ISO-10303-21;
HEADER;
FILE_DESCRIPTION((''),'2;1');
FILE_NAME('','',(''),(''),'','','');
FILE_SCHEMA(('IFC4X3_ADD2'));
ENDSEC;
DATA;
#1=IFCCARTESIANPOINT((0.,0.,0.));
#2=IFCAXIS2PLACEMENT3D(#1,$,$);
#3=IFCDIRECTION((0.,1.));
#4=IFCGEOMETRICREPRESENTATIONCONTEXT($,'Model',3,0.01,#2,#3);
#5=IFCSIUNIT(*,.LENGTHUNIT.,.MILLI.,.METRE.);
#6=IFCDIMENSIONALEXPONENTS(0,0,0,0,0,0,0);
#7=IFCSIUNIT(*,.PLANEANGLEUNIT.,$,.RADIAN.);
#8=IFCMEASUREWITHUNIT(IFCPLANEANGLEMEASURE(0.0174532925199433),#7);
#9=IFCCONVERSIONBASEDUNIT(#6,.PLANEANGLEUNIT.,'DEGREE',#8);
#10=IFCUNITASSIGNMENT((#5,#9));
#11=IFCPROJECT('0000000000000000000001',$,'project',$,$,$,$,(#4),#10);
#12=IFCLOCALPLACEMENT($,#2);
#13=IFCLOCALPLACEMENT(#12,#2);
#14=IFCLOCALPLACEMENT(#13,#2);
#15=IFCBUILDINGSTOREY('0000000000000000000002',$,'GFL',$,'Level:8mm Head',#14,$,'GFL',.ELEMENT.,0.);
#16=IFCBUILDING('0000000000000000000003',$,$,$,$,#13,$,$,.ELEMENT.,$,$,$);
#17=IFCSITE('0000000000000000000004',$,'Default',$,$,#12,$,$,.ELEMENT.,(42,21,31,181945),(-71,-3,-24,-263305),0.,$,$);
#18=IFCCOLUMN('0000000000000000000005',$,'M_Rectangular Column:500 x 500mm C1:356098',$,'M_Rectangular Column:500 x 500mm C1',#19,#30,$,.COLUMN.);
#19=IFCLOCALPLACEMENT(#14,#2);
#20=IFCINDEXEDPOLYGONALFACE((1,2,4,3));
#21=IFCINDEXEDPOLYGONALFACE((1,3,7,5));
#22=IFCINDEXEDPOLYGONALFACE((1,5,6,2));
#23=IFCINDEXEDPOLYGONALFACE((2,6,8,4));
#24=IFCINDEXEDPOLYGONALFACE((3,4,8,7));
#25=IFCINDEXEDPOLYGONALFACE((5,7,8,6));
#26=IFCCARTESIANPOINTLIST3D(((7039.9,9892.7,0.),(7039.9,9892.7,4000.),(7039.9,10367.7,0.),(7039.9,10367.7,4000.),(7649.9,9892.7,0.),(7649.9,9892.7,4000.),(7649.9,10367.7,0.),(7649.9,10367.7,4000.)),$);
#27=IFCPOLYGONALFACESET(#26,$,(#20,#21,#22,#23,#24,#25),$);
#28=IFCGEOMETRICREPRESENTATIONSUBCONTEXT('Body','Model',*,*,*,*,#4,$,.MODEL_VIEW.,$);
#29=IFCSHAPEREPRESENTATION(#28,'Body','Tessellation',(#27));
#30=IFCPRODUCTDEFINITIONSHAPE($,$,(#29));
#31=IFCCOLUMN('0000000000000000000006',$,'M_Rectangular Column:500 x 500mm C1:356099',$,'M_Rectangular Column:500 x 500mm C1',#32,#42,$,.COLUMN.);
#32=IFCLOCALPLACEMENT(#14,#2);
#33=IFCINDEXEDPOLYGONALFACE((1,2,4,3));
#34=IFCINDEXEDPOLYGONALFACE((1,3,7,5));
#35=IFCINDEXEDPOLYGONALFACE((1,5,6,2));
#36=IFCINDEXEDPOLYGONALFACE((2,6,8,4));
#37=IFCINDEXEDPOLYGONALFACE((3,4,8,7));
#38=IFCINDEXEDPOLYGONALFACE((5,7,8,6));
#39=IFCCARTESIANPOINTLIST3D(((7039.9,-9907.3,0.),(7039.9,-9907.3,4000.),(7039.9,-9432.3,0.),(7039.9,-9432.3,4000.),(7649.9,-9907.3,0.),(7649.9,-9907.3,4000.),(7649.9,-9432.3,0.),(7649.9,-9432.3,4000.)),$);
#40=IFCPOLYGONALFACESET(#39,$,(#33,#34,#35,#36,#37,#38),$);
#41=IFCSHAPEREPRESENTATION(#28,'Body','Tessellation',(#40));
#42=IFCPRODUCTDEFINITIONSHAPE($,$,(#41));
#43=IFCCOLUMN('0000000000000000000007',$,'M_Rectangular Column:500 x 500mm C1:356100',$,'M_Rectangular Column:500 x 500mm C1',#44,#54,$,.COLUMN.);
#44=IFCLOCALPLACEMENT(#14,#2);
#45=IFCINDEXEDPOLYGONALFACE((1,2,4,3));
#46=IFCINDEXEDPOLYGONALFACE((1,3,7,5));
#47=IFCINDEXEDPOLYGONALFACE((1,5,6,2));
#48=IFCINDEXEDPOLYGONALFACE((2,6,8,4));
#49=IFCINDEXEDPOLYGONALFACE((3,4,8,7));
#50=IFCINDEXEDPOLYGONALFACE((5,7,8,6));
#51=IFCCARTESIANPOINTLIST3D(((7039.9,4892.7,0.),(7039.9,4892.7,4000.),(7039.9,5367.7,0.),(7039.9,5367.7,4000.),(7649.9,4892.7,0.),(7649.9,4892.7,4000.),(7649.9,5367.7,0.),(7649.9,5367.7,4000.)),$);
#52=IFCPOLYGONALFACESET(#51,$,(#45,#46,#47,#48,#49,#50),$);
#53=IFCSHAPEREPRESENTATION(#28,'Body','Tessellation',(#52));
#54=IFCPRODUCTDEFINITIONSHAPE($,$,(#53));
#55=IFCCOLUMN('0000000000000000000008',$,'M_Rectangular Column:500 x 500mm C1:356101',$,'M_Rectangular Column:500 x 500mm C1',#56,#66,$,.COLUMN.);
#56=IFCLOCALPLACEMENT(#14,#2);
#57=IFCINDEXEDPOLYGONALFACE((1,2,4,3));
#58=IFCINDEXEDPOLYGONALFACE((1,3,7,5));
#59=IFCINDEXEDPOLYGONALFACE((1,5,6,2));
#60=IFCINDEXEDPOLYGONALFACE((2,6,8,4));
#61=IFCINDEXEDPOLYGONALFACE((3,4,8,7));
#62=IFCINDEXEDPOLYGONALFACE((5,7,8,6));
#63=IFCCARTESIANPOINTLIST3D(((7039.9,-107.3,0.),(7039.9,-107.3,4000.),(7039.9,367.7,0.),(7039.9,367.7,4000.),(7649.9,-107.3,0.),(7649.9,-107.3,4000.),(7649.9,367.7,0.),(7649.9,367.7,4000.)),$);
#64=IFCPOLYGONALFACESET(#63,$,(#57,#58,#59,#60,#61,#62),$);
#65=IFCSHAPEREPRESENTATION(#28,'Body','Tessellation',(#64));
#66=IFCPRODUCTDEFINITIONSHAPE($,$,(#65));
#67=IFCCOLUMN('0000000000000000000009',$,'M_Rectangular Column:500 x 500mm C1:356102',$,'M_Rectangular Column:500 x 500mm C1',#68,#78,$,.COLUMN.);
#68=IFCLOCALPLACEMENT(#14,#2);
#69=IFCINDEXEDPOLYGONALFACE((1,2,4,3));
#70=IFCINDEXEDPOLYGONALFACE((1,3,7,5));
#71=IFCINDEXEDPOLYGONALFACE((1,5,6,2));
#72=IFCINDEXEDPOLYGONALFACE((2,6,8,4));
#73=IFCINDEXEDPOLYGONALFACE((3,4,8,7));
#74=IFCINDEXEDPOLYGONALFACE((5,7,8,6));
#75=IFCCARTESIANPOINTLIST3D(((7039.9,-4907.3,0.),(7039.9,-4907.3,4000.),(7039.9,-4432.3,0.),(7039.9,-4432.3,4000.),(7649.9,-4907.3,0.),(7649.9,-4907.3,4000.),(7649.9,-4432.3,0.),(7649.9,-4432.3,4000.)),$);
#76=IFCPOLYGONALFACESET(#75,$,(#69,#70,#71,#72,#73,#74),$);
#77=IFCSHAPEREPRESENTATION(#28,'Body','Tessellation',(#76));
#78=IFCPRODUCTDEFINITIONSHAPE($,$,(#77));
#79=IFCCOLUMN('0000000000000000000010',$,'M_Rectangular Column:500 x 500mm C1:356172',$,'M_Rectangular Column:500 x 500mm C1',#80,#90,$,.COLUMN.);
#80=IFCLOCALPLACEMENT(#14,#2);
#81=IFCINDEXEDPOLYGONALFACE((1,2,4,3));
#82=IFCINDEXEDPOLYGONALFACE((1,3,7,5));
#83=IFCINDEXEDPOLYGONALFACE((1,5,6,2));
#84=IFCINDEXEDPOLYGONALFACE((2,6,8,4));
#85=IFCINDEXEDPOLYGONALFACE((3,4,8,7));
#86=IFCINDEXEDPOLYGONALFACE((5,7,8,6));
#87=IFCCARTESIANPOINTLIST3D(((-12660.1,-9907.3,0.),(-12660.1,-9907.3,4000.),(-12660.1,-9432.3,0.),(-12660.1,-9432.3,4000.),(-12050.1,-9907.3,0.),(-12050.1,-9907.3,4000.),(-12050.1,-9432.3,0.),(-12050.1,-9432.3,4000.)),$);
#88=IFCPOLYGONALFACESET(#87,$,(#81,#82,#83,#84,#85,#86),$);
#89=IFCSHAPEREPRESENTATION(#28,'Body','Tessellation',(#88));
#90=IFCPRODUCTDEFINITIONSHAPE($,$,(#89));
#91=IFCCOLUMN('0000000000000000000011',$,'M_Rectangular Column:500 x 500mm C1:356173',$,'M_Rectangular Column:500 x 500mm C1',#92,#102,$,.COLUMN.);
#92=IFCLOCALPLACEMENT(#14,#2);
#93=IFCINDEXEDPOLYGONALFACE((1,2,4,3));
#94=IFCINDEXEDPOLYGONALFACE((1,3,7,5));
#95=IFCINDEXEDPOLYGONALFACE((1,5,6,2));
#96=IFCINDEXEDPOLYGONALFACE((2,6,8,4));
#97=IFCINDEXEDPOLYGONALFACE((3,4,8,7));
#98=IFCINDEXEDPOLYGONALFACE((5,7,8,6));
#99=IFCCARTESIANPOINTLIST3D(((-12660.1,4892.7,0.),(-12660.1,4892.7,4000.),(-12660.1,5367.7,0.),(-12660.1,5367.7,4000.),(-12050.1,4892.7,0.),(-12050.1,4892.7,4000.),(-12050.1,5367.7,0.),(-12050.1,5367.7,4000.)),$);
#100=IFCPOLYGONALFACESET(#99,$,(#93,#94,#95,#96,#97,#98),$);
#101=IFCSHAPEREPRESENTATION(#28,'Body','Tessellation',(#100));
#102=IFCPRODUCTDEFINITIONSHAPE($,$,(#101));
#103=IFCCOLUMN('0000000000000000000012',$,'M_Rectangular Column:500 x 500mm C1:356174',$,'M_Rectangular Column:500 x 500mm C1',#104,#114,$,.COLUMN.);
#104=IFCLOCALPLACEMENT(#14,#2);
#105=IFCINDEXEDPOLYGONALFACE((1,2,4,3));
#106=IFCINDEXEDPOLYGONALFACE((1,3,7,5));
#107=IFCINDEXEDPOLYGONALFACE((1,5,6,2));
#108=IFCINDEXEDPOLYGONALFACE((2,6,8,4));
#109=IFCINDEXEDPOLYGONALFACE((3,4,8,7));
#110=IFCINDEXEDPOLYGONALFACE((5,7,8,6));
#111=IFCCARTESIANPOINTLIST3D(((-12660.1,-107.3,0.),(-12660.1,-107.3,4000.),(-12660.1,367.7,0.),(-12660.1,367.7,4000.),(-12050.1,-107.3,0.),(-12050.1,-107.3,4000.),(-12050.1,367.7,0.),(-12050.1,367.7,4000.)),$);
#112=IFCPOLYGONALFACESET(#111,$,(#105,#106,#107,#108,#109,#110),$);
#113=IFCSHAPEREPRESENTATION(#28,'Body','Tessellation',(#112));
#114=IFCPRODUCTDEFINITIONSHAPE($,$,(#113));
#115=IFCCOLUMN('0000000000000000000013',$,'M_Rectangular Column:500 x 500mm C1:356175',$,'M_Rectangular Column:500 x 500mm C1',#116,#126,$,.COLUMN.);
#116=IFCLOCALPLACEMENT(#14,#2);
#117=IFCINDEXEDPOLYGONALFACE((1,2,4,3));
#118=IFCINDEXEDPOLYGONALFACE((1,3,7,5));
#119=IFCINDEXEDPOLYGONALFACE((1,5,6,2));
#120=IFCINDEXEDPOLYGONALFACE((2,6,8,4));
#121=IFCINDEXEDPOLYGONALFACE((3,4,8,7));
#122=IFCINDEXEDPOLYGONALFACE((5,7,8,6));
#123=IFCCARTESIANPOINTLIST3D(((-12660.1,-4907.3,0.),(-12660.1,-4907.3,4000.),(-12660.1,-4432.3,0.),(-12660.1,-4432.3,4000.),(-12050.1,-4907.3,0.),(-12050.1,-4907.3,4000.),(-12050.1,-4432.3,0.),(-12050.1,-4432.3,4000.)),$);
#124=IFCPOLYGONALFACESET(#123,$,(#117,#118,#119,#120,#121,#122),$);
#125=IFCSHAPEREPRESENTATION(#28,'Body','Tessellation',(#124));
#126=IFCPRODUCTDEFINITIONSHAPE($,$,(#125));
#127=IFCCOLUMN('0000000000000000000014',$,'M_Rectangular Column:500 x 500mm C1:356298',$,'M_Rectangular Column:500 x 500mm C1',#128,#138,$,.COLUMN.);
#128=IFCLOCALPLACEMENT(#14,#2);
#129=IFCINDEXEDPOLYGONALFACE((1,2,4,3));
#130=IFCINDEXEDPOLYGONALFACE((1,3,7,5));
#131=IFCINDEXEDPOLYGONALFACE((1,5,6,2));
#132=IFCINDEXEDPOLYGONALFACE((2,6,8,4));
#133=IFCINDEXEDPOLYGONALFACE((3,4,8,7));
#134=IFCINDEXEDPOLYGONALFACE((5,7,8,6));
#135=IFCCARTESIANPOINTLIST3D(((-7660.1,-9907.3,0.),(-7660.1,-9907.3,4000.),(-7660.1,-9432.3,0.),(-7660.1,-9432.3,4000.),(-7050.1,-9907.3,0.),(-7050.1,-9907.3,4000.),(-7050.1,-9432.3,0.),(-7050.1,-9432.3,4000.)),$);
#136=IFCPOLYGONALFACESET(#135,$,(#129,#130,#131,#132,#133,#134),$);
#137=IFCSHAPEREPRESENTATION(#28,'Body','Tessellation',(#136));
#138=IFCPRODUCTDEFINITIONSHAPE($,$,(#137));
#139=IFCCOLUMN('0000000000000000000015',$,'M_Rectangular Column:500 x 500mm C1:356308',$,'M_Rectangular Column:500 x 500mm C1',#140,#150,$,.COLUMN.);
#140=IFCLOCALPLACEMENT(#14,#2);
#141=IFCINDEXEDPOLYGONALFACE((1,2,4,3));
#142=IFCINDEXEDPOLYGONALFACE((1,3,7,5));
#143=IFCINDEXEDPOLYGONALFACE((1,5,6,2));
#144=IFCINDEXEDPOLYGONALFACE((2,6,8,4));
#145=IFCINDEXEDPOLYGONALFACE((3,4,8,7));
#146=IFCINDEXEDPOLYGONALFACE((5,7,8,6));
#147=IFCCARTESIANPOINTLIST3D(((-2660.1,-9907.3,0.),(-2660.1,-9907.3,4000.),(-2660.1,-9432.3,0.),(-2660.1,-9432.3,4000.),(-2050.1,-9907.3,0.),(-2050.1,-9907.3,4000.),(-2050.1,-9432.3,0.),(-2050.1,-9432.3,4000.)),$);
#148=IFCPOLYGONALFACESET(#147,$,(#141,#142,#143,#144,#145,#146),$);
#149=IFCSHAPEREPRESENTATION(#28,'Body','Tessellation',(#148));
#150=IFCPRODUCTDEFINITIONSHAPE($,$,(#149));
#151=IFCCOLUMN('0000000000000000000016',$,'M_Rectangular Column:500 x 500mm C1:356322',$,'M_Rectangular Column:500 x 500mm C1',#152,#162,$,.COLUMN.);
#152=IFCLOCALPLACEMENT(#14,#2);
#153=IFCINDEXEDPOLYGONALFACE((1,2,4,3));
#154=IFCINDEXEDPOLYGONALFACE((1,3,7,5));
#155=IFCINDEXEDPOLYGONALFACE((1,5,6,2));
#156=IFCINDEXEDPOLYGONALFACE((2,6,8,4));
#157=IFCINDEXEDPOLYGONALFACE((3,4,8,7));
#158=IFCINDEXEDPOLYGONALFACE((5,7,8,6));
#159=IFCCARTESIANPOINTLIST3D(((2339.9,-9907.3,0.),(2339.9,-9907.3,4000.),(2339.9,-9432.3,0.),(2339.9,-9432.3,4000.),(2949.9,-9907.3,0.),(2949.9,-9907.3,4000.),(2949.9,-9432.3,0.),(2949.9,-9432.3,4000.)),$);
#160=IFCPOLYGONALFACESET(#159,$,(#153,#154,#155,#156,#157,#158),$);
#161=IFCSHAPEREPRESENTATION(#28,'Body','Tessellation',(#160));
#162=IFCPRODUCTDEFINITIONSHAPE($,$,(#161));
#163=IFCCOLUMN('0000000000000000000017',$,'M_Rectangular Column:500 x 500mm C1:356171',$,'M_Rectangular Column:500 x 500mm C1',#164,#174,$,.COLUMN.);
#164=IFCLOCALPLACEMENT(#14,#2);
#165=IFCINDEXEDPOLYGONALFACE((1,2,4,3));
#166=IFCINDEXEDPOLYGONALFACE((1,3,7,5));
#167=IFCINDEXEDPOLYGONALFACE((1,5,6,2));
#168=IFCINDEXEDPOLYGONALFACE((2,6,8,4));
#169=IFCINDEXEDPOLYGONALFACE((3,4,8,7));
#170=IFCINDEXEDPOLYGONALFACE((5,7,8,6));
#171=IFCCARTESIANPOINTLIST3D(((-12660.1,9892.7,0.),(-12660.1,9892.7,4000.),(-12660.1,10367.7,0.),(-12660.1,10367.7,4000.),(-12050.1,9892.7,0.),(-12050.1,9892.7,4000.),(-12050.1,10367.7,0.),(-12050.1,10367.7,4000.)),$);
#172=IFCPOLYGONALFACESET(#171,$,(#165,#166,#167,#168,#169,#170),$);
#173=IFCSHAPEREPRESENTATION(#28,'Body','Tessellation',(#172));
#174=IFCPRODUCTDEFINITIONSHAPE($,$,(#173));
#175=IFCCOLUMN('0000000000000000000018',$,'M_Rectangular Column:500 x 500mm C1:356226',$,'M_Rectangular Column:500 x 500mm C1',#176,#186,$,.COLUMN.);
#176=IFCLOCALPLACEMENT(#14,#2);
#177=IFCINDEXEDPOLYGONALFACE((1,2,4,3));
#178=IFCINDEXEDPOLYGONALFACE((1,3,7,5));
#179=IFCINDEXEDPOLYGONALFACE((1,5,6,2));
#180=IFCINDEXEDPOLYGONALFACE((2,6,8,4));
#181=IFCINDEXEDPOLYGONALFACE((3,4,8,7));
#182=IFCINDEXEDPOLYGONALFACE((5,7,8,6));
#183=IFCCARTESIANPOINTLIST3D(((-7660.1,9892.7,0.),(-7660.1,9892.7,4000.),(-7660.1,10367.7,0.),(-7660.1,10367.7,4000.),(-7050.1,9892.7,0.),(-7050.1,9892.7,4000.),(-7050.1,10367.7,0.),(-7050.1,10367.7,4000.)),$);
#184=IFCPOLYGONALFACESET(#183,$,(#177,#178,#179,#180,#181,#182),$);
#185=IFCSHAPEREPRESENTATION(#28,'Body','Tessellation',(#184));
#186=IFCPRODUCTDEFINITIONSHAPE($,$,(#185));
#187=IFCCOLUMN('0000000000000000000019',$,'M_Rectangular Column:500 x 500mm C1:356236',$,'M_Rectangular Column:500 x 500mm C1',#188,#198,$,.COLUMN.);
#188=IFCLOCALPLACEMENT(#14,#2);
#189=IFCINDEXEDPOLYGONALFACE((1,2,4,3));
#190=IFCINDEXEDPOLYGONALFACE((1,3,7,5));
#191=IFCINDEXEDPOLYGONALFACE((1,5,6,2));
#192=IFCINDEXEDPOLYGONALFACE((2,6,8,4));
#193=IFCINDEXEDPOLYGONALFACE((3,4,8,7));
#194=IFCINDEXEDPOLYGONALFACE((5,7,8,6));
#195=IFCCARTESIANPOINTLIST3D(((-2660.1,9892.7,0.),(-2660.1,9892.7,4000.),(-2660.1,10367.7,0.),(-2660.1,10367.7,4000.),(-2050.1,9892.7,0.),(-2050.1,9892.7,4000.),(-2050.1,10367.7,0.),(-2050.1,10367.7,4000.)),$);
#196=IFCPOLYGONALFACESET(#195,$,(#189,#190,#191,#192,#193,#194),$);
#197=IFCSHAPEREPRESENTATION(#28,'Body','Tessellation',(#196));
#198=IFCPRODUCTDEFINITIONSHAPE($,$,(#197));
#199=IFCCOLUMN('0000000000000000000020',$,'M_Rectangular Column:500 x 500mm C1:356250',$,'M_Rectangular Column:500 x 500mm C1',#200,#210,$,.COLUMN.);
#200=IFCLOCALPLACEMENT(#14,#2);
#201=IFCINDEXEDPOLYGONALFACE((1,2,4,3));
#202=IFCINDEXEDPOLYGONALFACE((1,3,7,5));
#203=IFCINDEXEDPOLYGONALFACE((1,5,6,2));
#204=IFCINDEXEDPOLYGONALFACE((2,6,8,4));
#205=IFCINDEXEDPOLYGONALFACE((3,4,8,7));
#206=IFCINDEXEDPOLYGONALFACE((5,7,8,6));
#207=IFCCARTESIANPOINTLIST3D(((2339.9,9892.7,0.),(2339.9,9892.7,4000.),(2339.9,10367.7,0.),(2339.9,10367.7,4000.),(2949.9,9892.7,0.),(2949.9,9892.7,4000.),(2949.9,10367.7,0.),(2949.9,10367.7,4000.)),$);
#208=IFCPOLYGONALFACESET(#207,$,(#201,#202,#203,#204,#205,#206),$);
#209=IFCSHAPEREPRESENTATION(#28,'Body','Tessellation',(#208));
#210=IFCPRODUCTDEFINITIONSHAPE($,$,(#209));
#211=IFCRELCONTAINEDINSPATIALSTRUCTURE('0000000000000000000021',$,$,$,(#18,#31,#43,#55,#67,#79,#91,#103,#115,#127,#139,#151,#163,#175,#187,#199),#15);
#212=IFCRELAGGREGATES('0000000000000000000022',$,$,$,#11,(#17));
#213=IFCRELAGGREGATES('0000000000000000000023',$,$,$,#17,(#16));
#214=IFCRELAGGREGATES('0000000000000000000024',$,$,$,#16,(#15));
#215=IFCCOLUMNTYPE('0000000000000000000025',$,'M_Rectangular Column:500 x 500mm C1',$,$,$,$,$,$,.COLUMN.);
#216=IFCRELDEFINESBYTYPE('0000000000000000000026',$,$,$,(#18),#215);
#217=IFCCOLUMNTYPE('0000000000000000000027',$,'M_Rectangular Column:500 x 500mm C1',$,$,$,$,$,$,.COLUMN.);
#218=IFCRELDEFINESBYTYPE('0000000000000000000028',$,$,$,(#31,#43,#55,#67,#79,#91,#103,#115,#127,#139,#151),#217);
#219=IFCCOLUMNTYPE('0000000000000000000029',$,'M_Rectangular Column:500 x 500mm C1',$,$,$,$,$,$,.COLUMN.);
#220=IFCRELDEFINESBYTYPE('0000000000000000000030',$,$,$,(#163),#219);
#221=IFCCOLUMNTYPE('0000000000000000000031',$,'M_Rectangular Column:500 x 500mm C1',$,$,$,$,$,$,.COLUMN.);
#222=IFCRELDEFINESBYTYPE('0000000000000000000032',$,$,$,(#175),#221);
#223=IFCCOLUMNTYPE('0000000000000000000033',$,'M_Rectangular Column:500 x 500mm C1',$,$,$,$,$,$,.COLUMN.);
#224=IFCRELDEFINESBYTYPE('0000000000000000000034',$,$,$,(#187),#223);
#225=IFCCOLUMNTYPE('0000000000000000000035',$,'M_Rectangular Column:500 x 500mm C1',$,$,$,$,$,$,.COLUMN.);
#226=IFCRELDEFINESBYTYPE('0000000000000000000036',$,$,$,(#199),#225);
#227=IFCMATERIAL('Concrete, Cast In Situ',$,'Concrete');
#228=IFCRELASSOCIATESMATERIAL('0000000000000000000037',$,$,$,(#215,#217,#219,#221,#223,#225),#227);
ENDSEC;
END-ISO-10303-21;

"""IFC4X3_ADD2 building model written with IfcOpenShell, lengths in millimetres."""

from ifc_helpers import new_model, entity, si_unit, converted_unit, direction, frame, frame_2d, origin, origin_2d_with_axis, place, context, subcontext, project, spatial, rectangle, extrude, source, transform, mapped, material, material_profile, profile_set, type_object, type_shapes, element, save


model = new_model("IFC4X3_ADD2")

# Units and contexts
model_context = context("Model", 3, precision=0.01, world=origin(), true_north=direction((0.0, 1.0)))
body_context = subcontext(model_context, "Body", "Model", "MODEL_VIEW")
ifc_project = project(units=[si_unit("LENGTHUNIT", "METRE", prefix="MILLI"), converted_unit("PLANEANGLEUNIT", "DEGREE", entity("IfcPlaneAngleMeasure", 0.0174532925199433), si_unit("PLANEANGLEUNIT", "RADIAN"), dimensions=[0, 0, 0, 0, 0, 0, 0])], contexts=[model_context])

# Site, building, storey
site_placement = place(None, origin())
site = spatial("IfcSite", under=ifc_project, at=site_placement, Name="Default", CompositionType="ELEMENT", RefLatitude=(42, 21, 31, 181945), RefLongitude=(-71, -3, -24, -263305), RefElevation=0.0)
building_placement = place(site_placement, origin())
building = spatial("IfcBuilding", under=site, at=building_placement, CompositionType="ELEMENT")
storey_placement = place(building_placement, origin())
storey = spatial("IfcBuildingStorey", under=building, at=storey_placement, Name="GFL", ObjectType="Level:8mm Head", LongName="GFL", CompositionType="ELEMENT", Elevation=0.0)

# Columns
ifc_material_1 = material(Name="Concrete, Cast In Situ", Category="Concrete")
ifc_material_profile_1 = material_profile(ifc_material_1, rectangle(XDim=610.0, YDim=475.0, at=frame_2d((0.0, 0.0), x_axis=(1.0, 0.0))), Name="500 x 500mm C1")
ifc_profile_set_1 = profile_set([ifc_material_profile_1], Name="500 x 500mm C1")
column_type_1 = type_object("IfcColumnType", Name="M_Rectangular Column:500 x 500mm C1", PredefinedType="COLUMN", material=ifc_profile_set_1)
shared_shape_1 = source(origin(), body_context, "Body", "SweptSolid", [
    extrude(rectangle(XDim=610.0, YDim=475.0, at=frame_2d((0.0, 0.0), x_axis=(1.0, 0.0))), frame((7344.9, 10130.2, 0.0), z_axis=(0.0, 0.0, 1.0), x_axis=(-1.0, 0.0, 0.0)), (0.0, 0.0, 1.0), 4000.0),
])
type_shapes(column_type_1, [shared_shape_1])
column_1_placement = place(storey_placement, origin())
element("IfcColumn", 1, at=column_1_placement, inside=storey, type_object=column_type_1, Name="M_Rectangular Column:500 x 500mm C1:356098", ObjectType="M_Rectangular Column:500 x 500mm C1", PredefinedType="COLUMN", context=body_context, shape_type="MappedRepresentation", body=[
    mapped(shared_shape_1, transform((0.0, 0.0, 0.0), scale=1.0)),
])
column_type_2 = type_object("IfcColumnType", Name="M_Rectangular Column:500 x 500mm C1", PredefinedType="COLUMN", material=ifc_profile_set_1)
shared_shape_2 = source(origin(), body_context, "Body", "SweptSolid", [
    extrude(rectangle(XDim=610.0, YDim=475.0, at=origin_2d_with_axis()), frame((0.0, 0.0, 0.0), z_axis=(0.0, 0.0, 1.0), x_axis=(-1.0, 0.0, 0.0)), (0.0, 0.0, 1.0), 4000.0),
])
type_shapes(column_type_2, [shared_shape_2])
for number, where, name in (
    (2, (7344.9, -9669.8, 0.0), "M_Rectangular Column:500 x 500mm C1:356099"),
    (3, (7344.9, 5130.2, 0.0), "M_Rectangular Column:500 x 500mm C1:356100"),
    (4, (7344.9, 130.2, 0.0), "M_Rectangular Column:500 x 500mm C1:356101"),
    (5, (7344.9, -4669.8, 0.0), "M_Rectangular Column:500 x 500mm C1:356102"),
    (6, (-12355.1, -9669.8, 0.0), "M_Rectangular Column:500 x 500mm C1:356172"),
    (7, (-12355.1, 5130.2, 0.0), "M_Rectangular Column:500 x 500mm C1:356173"),
    (8, (-12355.1, 130.2, 0.0), "M_Rectangular Column:500 x 500mm C1:356174"),
    (9, (-12355.1, -4669.8, 0.0), "M_Rectangular Column:500 x 500mm C1:356175"),
    (10, (-7355.1, -9669.8, 0.0), "M_Rectangular Column:500 x 500mm C1:356298"),
    (11, (-2355.1, -9669.8, 0.0), "M_Rectangular Column:500 x 500mm C1:356308"),
    (12, (2644.9, -9669.8, 0.0), "M_Rectangular Column:500 x 500mm C1:356322"),
):
    element("IfcColumn", number, at=place(storey_placement, frame(where)), inside=storey, type_object=column_type_2, Name=name, ObjectType="M_Rectangular Column:500 x 500mm C1", PredefinedType="COLUMN", context=body_context, shape_type="MappedRepresentation", body=[
        mapped(shared_shape_2, transform((0.0, 0.0, 0.0), scale=1.0)),
    ])
column_type_3 = type_object("IfcColumnType", Name="M_Rectangular Column:500 x 500mm C1", PredefinedType="COLUMN", material=ifc_profile_set_1)
shared_shape_3 = source(origin(), body_context, "Body", "SweptSolid", [
    extrude(rectangle(XDim=610.0, YDim=475.0, at=frame_2d((0.0, 0.0), x_axis=(1.0, 0.0))), frame((-12355.1, 10130.2, 0.0), z_axis=(0.0, 0.0, 1.0), x_axis=(-1.0, 0.0, 0.0)), (0.0, 0.0, 1.0), 4000.0),
])
type_shapes(column_type_3, [shared_shape_3])
column_2_placement = place(storey_placement, origin())
element("IfcColumn", 13, at=column_2_placement, inside=storey, type_object=column_type_3, Name="M_Rectangular Column:500 x 500mm C1:356171", ObjectType="M_Rectangular Column:500 x 500mm C1", PredefinedType="COLUMN", context=body_context, shape_type="MappedRepresentation", body=[
    mapped(shared_shape_3, transform((0.0, 0.0, 0.0), scale=1.0)),
])
column_type_4 = type_object("IfcColumnType", Name="M_Rectangular Column:500 x 500mm C1", PredefinedType="COLUMN", material=ifc_profile_set_1)
shared_shape_4 = source(origin(), body_context, "Body", "SweptSolid", [
    extrude(rectangle(XDim=610.0, YDim=475.0, at=frame_2d((0.0, 0.0), x_axis=(1.0, 0.0))), frame((-7355.1, 10130.2, 0.0), z_axis=(0.0, 0.0, 1.0), x_axis=(-1.0, 0.0, 0.0)), (0.0, 0.0, 1.0), 4000.0),
])
type_shapes(column_type_4, [shared_shape_4])
column_3_placement = place(storey_placement, origin())
element("IfcColumn", 14, at=column_3_placement, inside=storey, type_object=column_type_4, Name="M_Rectangular Column:500 x 500mm C1:356226", ObjectType="M_Rectangular Column:500 x 500mm C1", PredefinedType="COLUMN", context=body_context, shape_type="MappedRepresentation", body=[
    mapped(shared_shape_4, transform((0.0, 0.0, 0.0), scale=1.0)),
])
column_type_5 = type_object("IfcColumnType", Name="M_Rectangular Column:500 x 500mm C1", PredefinedType="COLUMN", material=ifc_profile_set_1)
shared_shape_5 = source(origin(), body_context, "Body", "SweptSolid", [
    extrude(rectangle(XDim=610.0, YDim=475.0, at=frame_2d((0.0, 0.0), x_axis=(1.0, 0.0))), frame((-2355.1, 10130.2, 0.0), z_axis=(0.0, 0.0, 1.0), x_axis=(-1.0, 0.0, 0.0)), (0.0, 0.0, 1.0), 4000.0),
])
type_shapes(column_type_5, [shared_shape_5])
column_4_placement = place(storey_placement, origin())
element("IfcColumn", 15, at=column_4_placement, inside=storey, type_object=column_type_5, Name="M_Rectangular Column:500 x 500mm C1:356236", ObjectType="M_Rectangular Column:500 x 500mm C1", PredefinedType="COLUMN", context=body_context, shape_type="MappedRepresentation", body=[
    mapped(shared_shape_5, transform((0.0, 0.0, 0.0), scale=1.0)),
])
column_type_6 = type_object("IfcColumnType", Name="M_Rectangular Column:500 x 500mm C1", PredefinedType="COLUMN", material=ifc_profile_set_1)
shared_shape_6 = source(origin(), body_context, "Body", "SweptSolid", [
    extrude(rectangle(XDim=610.0, YDim=475.0, at=frame_2d((0.0, 0.0), x_axis=(1.0, 0.0))), frame((2644.9, 10130.2, 0.0), z_axis=(0.0, 0.0, 1.0), x_axis=(-1.0, 0.0, 0.0)), (0.0, 0.0, 1.0), 4000.0),
])
type_shapes(column_type_6, [shared_shape_6])
column_5_placement = place(storey_placement, origin())
element("IfcColumn", 16, at=column_5_placement, inside=storey, type_object=column_type_6, Name="M_Rectangular Column:500 x 500mm C1:356250", ObjectType="M_Rectangular Column:500 x 500mm C1", PredefinedType="COLUMN", context=body_context, shape_type="MappedRepresentation", body=[
    mapped(shared_shape_6, transform((0.0, 0.0, 0.0), scale=1.0)),
])

save(model, "model.ifc")
